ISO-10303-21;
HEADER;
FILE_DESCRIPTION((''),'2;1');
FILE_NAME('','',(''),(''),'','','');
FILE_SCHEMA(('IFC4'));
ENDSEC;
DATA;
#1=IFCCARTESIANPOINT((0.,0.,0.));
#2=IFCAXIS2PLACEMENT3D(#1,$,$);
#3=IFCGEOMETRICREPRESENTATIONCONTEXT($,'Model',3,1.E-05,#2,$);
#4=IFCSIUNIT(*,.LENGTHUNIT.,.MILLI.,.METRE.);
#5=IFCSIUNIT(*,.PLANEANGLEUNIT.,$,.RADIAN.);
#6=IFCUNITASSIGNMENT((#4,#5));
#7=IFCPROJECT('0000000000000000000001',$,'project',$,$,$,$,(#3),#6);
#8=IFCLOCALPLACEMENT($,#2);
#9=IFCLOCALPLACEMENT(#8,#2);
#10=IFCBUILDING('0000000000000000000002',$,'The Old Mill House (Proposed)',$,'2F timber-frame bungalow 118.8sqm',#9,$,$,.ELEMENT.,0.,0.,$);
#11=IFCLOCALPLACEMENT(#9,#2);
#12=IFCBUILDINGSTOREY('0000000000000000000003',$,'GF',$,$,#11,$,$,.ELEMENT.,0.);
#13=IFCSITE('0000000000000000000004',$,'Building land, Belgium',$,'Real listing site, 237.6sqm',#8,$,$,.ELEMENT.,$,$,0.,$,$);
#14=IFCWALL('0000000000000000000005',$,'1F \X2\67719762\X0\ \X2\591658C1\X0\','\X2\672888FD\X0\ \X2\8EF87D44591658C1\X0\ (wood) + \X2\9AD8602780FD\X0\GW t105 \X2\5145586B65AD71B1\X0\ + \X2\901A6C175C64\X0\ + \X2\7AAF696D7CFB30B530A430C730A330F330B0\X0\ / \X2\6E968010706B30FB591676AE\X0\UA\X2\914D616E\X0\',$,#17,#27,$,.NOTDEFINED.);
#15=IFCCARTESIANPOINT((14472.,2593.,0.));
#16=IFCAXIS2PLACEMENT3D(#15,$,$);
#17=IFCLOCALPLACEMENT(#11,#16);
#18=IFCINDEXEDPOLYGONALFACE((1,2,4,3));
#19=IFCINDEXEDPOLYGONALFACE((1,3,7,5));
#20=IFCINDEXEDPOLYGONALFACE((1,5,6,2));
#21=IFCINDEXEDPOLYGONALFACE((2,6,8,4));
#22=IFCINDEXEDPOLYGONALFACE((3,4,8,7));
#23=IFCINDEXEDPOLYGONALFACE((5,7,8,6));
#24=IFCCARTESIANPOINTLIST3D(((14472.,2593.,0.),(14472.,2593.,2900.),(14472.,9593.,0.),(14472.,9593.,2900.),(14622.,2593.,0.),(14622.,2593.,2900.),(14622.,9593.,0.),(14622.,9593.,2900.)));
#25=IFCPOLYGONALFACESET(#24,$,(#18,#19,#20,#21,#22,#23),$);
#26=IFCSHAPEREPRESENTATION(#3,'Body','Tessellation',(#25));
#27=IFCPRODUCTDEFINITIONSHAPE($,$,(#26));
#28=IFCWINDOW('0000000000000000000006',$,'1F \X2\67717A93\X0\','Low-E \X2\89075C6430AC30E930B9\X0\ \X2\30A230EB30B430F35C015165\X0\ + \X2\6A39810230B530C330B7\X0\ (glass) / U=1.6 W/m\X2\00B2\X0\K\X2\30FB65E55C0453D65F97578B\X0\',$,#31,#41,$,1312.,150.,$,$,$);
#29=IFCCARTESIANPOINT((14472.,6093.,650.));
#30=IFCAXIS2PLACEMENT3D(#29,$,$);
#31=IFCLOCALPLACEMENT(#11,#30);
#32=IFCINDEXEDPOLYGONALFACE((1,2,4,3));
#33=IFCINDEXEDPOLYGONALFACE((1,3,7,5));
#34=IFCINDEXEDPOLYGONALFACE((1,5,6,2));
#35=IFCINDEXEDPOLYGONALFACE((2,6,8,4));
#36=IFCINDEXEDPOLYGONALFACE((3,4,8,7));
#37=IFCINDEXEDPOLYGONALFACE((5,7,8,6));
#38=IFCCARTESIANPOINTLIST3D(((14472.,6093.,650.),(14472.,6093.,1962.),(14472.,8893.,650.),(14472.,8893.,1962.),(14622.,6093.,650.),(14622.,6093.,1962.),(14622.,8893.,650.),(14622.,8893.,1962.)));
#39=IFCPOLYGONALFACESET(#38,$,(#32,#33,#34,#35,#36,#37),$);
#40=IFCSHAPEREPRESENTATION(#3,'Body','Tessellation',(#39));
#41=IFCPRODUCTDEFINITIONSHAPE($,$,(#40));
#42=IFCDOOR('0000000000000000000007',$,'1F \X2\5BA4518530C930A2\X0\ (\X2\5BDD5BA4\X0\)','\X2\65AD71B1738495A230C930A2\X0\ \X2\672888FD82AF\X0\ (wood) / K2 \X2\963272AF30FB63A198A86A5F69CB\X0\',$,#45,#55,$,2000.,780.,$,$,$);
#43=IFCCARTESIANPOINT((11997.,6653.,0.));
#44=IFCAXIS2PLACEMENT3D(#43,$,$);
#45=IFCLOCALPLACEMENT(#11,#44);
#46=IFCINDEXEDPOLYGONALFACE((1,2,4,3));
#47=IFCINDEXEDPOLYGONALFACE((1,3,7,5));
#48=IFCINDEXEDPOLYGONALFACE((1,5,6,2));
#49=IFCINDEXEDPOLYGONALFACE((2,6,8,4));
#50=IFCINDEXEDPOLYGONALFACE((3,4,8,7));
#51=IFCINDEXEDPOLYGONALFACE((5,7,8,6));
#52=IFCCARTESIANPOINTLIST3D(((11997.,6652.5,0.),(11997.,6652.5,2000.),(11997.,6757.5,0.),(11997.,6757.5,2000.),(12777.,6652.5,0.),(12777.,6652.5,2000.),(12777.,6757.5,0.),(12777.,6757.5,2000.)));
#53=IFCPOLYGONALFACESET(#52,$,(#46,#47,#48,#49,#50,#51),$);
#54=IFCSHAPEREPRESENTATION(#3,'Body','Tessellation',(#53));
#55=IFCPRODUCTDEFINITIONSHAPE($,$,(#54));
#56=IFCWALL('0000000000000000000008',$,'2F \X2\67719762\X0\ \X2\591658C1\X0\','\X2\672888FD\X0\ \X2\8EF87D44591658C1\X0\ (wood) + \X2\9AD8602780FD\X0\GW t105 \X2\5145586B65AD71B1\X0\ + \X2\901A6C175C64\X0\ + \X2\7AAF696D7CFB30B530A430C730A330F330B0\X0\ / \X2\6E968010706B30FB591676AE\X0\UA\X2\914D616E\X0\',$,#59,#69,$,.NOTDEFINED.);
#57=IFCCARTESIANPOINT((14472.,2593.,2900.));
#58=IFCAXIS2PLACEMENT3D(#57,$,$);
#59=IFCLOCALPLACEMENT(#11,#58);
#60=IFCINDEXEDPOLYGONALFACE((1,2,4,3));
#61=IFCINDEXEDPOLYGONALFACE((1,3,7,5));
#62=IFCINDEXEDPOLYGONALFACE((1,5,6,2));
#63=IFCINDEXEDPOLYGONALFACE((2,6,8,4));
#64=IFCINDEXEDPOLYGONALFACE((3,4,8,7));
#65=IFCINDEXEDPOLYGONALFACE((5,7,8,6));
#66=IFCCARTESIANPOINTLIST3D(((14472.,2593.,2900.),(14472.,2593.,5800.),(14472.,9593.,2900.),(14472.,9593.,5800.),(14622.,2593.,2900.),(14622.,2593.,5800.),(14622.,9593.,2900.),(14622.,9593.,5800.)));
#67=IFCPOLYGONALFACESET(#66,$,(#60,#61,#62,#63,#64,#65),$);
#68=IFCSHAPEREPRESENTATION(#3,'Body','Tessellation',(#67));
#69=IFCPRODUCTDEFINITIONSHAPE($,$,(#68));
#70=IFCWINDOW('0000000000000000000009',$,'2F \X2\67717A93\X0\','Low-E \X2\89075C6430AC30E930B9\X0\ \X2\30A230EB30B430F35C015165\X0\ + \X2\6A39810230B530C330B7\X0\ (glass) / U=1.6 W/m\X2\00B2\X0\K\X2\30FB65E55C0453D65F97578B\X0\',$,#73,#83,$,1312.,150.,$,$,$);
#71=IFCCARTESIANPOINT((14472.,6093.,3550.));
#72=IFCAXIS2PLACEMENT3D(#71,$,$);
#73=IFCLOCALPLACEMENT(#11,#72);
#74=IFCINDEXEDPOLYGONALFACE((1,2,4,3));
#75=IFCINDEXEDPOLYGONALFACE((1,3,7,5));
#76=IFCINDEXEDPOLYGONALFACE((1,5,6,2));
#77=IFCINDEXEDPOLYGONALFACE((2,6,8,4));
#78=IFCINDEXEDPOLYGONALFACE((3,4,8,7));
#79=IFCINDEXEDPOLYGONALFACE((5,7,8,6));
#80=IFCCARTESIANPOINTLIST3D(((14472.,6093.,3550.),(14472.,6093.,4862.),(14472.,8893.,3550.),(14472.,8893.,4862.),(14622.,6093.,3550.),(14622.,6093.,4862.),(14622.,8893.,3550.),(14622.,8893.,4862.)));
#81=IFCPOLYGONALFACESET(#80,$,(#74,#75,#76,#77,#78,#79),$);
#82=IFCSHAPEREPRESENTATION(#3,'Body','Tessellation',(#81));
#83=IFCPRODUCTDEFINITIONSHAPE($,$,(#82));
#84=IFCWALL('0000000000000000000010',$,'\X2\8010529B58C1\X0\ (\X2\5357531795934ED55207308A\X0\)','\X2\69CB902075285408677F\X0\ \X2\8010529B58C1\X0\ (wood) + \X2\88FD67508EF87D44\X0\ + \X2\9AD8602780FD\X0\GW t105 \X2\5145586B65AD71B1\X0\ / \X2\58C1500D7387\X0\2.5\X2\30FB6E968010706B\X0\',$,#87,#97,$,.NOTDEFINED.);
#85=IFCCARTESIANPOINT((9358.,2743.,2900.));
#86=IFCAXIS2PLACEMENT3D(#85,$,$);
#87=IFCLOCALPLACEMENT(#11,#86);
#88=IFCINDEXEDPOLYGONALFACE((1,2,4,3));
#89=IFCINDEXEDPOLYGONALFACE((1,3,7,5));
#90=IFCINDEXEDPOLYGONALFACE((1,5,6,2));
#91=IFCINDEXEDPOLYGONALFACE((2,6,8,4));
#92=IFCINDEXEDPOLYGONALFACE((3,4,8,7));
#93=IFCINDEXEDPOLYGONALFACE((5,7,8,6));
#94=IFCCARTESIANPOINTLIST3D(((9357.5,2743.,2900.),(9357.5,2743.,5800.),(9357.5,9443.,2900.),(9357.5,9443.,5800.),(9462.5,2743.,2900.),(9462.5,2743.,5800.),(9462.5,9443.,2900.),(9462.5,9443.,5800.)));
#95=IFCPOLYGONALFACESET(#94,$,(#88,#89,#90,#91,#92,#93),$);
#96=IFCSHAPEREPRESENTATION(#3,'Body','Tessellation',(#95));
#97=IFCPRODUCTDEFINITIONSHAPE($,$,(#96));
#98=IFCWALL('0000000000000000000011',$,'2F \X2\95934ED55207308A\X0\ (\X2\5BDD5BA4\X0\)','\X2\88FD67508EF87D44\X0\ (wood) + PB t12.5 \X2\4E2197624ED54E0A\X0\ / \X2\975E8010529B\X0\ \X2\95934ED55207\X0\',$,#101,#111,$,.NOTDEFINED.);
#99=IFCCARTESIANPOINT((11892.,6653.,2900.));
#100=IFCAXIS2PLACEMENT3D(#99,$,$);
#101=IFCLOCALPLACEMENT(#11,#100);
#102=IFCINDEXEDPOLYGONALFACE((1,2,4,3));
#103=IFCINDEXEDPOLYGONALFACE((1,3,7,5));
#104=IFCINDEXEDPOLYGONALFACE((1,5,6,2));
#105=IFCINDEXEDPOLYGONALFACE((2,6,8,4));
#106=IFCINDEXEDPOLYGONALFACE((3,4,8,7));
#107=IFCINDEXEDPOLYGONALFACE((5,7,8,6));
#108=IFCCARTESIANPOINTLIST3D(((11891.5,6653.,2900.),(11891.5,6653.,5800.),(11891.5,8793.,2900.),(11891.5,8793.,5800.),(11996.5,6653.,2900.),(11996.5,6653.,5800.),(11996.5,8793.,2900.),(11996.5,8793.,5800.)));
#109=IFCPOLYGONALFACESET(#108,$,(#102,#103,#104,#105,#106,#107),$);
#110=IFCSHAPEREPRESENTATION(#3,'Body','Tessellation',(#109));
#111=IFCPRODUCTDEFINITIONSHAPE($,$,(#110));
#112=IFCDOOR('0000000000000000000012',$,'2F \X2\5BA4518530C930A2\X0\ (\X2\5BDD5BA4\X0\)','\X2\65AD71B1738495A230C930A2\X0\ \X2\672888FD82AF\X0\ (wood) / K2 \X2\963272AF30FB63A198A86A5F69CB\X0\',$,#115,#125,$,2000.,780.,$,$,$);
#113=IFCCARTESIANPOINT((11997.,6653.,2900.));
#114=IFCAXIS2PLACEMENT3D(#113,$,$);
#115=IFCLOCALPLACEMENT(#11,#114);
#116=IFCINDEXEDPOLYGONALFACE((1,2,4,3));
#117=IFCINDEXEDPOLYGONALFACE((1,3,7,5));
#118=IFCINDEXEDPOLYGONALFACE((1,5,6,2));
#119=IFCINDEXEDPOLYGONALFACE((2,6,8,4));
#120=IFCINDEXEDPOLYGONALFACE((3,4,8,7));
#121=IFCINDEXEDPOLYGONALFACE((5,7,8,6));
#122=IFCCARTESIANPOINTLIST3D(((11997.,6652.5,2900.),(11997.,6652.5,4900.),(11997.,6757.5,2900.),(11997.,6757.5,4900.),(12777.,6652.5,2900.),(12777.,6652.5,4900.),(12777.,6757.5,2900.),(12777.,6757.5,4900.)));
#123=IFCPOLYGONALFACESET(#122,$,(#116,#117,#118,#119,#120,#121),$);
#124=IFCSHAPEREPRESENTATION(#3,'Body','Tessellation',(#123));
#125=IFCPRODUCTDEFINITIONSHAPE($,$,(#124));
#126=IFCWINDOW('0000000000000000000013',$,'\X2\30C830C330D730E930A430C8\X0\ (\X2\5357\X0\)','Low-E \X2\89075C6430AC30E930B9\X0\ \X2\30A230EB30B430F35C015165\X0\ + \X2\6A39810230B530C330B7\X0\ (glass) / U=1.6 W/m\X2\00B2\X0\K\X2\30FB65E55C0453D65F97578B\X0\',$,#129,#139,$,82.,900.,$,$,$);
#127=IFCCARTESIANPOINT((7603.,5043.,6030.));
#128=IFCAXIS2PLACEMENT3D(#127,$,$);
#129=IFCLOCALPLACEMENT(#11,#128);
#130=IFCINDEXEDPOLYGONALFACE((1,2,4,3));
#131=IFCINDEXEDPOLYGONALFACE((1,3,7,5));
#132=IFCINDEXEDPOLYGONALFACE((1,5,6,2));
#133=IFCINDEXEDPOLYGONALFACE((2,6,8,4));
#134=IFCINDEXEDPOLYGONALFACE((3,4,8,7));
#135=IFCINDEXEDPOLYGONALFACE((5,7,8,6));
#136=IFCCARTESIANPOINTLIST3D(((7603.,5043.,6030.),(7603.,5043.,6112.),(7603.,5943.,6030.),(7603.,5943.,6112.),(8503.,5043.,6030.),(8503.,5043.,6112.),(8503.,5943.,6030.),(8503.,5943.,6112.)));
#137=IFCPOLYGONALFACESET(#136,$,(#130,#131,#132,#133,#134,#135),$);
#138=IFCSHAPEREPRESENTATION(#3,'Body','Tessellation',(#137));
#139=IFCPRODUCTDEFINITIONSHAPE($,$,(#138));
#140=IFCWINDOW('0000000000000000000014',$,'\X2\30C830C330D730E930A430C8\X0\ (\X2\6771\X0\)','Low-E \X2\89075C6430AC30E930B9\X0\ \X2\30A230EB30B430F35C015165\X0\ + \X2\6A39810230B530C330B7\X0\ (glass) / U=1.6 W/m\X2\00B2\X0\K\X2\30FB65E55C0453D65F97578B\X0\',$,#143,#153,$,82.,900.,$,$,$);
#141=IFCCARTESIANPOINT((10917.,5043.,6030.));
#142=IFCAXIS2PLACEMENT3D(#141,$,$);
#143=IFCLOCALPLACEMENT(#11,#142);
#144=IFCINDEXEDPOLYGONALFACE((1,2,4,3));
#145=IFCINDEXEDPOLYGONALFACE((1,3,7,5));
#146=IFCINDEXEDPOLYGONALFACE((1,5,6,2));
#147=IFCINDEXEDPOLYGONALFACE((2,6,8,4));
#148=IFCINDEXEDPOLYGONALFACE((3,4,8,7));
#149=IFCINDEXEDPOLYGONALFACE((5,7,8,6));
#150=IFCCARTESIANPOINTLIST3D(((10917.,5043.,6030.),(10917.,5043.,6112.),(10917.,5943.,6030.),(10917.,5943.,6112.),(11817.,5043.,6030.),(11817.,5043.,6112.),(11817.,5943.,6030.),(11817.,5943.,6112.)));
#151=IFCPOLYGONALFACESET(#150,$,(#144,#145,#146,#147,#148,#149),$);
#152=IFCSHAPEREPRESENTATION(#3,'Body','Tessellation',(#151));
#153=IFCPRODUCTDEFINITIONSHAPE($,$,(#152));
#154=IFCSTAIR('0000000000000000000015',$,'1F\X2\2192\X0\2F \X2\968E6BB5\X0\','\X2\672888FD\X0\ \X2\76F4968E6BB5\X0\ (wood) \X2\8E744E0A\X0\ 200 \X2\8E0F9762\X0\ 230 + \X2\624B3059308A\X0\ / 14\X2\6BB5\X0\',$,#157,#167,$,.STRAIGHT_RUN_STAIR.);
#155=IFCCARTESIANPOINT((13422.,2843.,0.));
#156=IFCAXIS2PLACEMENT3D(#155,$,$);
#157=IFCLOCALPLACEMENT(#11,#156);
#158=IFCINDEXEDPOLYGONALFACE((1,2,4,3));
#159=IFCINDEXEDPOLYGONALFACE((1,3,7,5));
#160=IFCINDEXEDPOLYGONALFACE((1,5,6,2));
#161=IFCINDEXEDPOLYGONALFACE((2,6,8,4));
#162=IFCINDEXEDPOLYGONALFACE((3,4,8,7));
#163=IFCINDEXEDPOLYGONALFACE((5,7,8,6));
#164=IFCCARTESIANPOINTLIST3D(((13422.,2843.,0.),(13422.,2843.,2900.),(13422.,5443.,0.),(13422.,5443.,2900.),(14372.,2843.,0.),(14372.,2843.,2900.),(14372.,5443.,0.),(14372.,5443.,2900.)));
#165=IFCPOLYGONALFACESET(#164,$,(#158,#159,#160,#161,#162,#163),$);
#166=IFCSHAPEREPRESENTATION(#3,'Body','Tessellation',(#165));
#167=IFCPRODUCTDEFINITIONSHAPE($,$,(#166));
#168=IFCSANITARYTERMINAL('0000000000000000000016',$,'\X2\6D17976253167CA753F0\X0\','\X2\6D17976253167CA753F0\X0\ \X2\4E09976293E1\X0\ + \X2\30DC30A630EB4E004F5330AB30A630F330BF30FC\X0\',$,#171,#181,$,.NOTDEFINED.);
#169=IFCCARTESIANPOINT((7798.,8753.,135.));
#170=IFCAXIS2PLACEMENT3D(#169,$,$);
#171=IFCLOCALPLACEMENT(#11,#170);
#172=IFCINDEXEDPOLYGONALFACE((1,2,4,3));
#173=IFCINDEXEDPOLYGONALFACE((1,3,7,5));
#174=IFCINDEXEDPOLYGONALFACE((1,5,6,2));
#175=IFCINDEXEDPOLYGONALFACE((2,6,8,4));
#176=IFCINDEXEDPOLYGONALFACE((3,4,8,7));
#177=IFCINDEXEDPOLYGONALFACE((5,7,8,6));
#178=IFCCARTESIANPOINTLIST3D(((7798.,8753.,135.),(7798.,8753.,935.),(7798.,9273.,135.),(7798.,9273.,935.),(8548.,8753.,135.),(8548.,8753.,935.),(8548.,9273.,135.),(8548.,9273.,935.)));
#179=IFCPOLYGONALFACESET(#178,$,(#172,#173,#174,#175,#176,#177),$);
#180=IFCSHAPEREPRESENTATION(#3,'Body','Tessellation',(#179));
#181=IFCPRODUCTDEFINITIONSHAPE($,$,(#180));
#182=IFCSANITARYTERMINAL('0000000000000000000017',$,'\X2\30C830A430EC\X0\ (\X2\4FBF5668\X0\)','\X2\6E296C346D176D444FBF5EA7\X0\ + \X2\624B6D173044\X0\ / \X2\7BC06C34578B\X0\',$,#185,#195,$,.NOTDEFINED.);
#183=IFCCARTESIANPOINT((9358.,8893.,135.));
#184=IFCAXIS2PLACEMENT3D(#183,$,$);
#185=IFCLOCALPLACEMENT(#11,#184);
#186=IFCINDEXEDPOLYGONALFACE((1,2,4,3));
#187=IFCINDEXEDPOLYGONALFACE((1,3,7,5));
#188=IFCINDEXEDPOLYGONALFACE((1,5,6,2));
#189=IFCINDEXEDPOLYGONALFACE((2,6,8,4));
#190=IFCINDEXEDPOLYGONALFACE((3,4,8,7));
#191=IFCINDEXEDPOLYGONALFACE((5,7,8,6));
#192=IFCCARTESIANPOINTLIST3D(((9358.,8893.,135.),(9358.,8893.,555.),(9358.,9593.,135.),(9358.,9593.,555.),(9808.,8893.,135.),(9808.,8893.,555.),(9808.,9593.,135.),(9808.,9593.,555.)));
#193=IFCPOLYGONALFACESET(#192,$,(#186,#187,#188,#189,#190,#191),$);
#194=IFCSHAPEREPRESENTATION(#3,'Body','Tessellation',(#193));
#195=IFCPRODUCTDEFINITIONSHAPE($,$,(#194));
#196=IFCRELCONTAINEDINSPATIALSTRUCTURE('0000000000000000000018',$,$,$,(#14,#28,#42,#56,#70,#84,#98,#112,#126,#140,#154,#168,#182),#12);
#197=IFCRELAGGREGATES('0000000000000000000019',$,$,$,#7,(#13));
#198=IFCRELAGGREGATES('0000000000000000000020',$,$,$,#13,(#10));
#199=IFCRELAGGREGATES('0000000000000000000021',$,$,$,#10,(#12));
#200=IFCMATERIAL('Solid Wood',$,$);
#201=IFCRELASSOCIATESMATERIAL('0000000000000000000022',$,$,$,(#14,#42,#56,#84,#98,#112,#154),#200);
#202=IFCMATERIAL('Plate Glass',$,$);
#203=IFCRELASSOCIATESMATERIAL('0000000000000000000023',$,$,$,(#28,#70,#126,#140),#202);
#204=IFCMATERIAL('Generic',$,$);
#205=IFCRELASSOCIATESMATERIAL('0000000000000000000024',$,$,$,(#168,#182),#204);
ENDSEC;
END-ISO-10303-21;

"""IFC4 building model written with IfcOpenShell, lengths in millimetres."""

from ifc_helpers import new_model, si_unit, frame, frame_2d, origin, place, context, project, spatial, rectangle, extrude, material, element, fill, save


model = new_model("IFC4")

# Units and contexts
model_context = context("Model", 3, precision=1e-05, world=origin())
ifc_project = project(units=[si_unit("LENGTHUNIT", "METRE", prefix="MILLI"), si_unit("PLANEANGLEUNIT", "RADIAN")], contexts=[model_context])

# Site, building, storey
site_placement = place(None, origin())
site = spatial("IfcSite", under=ifc_project, at=site_placement, Name="Building land, Belgium", ObjectType="Real listing site, 237.6sqm", CompositionType="ELEMENT", RefElevation=0.0)
building_placement = place(site_placement, origin())
building = spatial("IfcBuilding", under=site, at=building_placement, Name="The Old Mill House (Proposed)", ObjectType="2F timber-frame bungalow 118.8sqm", CompositionType="ELEMENT", ElevationOfRefHeight=0.0, ElevationOfTerrain=0.0)
storey_placement = place(building_placement, origin())
storey = spatial("IfcBuildingStorey", under=building, at=storey_placement, Name="GF", CompositionType="ELEMENT", Elevation=0.0)

# Wall, opening, window
ifc_material_1 = material(Name="Solid Wood")
wall_1_placement = place(storey_placement, frame((14472.0, 2593.0, 0.0)))
wall_1 = element("IfcWall", 1, at=wall_1_placement, inside=storey, material=ifc_material_1, Name="1F 東面 外壁", Description="木製 軸組外壁 (wood) + 高性能GW t105 充填断熱 + 通気層 + 窯業系サイディング / 準耐火・外皮UA配慮", PredefinedType="NOTDEFINED", context=model_context, shape_type="SweptSolid", body=[
    extrude(rectangle(XDim=150.0, YDim=7000.0, at=frame_2d((75.0, 3500.0))), frame((14472.0, 2593.0, 0.0)), (0.0, 0.0, 1.0), 2900.0),
])
opening_1_placement = place(storey_placement, frame((14472.0, 6093.0, 650.0)))
opening_1 = element("IfcOpeningElement", 2, at=opening_1_placement, cuts=wall_1, PredefinedType="NOTDEFINED", context=model_context, shape_type="SweptSolid", body=[
    extrude(rectangle(XDim=150.0, YDim=2800.0, at=frame_2d((75.0, 1400.0))), frame((14472.0, 6093.0, 650.0)), (0.0, 0.0, 1.0), 1312.0),
])
ifc_material_2 = material(Name="Plate Glass")
window_1_placement = place(storey_placement, frame((14472.0, 6093.0, 650.0)))
window_1 = element("IfcWindow", 3, at=window_1_placement, inside=storey, material=ifc_material_2, Name="1F 東窓", Description="Low-E 複層ガラス アルゴン封入 + 樹脂サッシ (glass) / U=1.6 W/m²K・日射取得型", OverallHeight=1312.0, OverallWidth=150.0, context=model_context, shape_type="SweptSolid", body=[
    extrude(rectangle(XDim=150.0, YDim=2800.0, at=frame_2d((75.0, 1400.0))), frame((14472.0, 6093.0, 650.0)), (0.0, 0.0, 1.0), 1312.0),
])
fill(opening_1, window_1)

# Door
door_1_placement = place(storey_placement, frame((11997.0, 6653.0, 0.0)))
element("IfcDoor", 4, at=door_1_placement, inside=storey, material=ifc_material_1, Name="1F 室内ドア (寝室)", Description="断熱玄関ドア 木製芯 (wood) / K2 防犯・採風機構", OverallHeight=2000.0, OverallWidth=780.0, context=model_context, shape_type="SweptSolid", body=[
    extrude(rectangle(XDim=780.0, YDim=105.0, at=frame_2d((390.0, 52.0))), frame((11997.0, 6653.0, 0.0)), (0.0, 0.0, 1.0), 2000.0),
])

# Wall, opening, window
wall_2_placement = place(storey_placement, frame((14472.0, 2593.0, 2900.0)))
wall_2 = element("IfcWall", 5, at=wall_2_placement, inside=storey, material=ifc_material_1, Name="2F 東面 外壁", Description="木製 軸組外壁 (wood) + 高性能GW t105 充填断熱 + 通気層 + 窯業系サイディング / 準耐火・外皮UA配慮", PredefinedType="NOTDEFINED", context=model_context, shape_type="SweptSolid", body=[
    extrude(rectangle(XDim=150.0, YDim=7000.0, at=frame_2d((75.0, 3500.0))), frame((14472.0, 2593.0, 2900.0)), (0.0, 0.0, 1.0), 2900.0),
])
opening_2_placement = place(storey_placement, frame((14472.0, 6093.0, 3550.0)))
opening_2 = element("IfcOpeningElement", 6, at=opening_2_placement, cuts=wall_2, PredefinedType="NOTDEFINED", context=model_context, shape_type="SweptSolid", body=[
    extrude(rectangle(XDim=150.0, YDim=2800.0, at=frame_2d((75.0, 1400.0))), frame((14472.0, 6093.0, 3550.0)), (0.0, 0.0, 1.0), 1312.0),
])
window_2_placement = place(storey_placement, frame((14472.0, 6093.0, 3550.0)))
window_2 = element("IfcWindow", 7, at=window_2_placement, inside=storey, material=ifc_material_2, Name="2F 東窓", Description="Low-E 複層ガラス アルゴン封入 + 樹脂サッシ (glass) / U=1.6 W/m²K・日射取得型", OverallHeight=1312.0, OverallWidth=150.0, context=model_context, shape_type="SweptSolid", body=[
    extrude(rectangle(XDim=150.0, YDim=2800.0, at=frame_2d((75.0, 1400.0))), frame((14472.0, 6093.0, 3550.0)), (0.0, 0.0, 1.0), 1312.0),
])
fill(opening_2, window_2)

# Walls
wall_3_placement = place(storey_placement, frame((9358.0, 2743.0, 2900.0)))
element("IfcWall", 8, at=wall_3_placement, inside=storey, material=ifc_material_1, Name="耐力壁 (南北間仕切り)", Description="構造用合板 耐力壁 (wood) + 製材軸組 + 高性能GW t105 充填断熱 / 壁倍率2.5・準耐火", PredefinedType="NOTDEFINED", context=model_context, shape_type="SweptSolid", body=[
    extrude(rectangle(XDim=105.0, YDim=6700.0, at=frame_2d((52.0, 3350.0))), frame((9358.0, 2743.0, 2900.0)), (0.0, 0.0, 1.0), 2900.0),
])
wall_4_placement = place(storey_placement, frame((11892.0, 6653.0, 2900.0)))
element("IfcWall", 9, at=wall_4_placement, inside=storey, material=ifc_material_1, Name="2F 間仕切り (寝室)", Description="製材軸組 (wood) + PB t12.5 両面仕上 / 非耐力 間仕切", PredefinedType="NOTDEFINED", context=model_context, shape_type="SweptSolid", body=[
    extrude(rectangle(XDim=105.0, YDim=2140.0, at=frame_2d((52.0, 1070.0))), frame((11892.0, 6653.0, 2900.0)), (0.0, 0.0, 1.0), 2900.0),
])

# Door
door_2_placement = place(storey_placement, frame((11997.0, 6653.0, 2900.0)))
element("IfcDoor", 10, at=door_2_placement, inside=storey, material=ifc_material_1, Name="2F 室内ドア (寝室)", Description="断熱玄関ドア 木製芯 (wood) / K2 防犯・採風機構", OverallHeight=2000.0, OverallWidth=780.0, context=model_context, shape_type="SweptSolid", body=[
    extrude(rectangle(XDim=780.0, YDim=105.0, at=frame_2d((390.0, 52.0))), frame((11997.0, 6653.0, 2900.0)), (0.0, 0.0, 1.0), 2000.0),
])

# Windows
window_3_placement = place(storey_placement, frame((7603.0, 5043.0, 6030.0)))
element("IfcWindow", 11, at=window_3_placement, inside=storey, material=ifc_material_2, Name="トップライト (南)", Description="Low-E 複層ガラス アルゴン封入 + 樹脂サッシ (glass) / U=1.6 W/m²K・日射取得型", OverallHeight=82.0, OverallWidth=900.0, context=model_context, shape_type="SweptSolid", body=[
    extrude(rectangle(XDim=900.0, YDim=900.0, at=frame_2d((450.0, 450.0))), frame((7603.0, 5043.0, 6030.0)), (0.0, 0.0, 1.0), 82.0),
])
window_4_placement = place(storey_placement, frame((10917.0, 5043.0, 6030.0)))
element("IfcWindow", 12, at=window_4_placement, inside=storey, material=ifc_material_2, Name="トップライト (東)", Description="Low-E 複層ガラス アルゴン封入 + 樹脂サッシ (glass) / U=1.6 W/m²K・日射取得型", OverallHeight=82.0, OverallWidth=900.0, context=model_context, shape_type="SweptSolid", body=[
    extrude(rectangle(XDim=900.0, YDim=900.0, at=frame_2d((450.0, 450.0))), frame((10917.0, 5043.0, 6030.0)), (0.0, 0.0, 1.0), 82.0),
])

# Stair
stair_placement = place(storey_placement, frame((13422.0, 2843.0, 0.0)))
element("IfcStair", 13, at=stair_placement, inside=storey, material=ifc_material_1, Name="1F→2F 階段", Description="木製 直階段 (wood) 蹴上 200 踏面 230 + 手すり / 14段", PredefinedType="STRAIGHT_RUN_STAIR", context=model_context, shape_type="SweptSolid", body=[
    extrude(rectangle(XDim=950.0, YDim=2600.0, at=frame_2d((475.0, 1300.0))), frame((13422.0, 2843.0, 0.0)), (0.0, 0.0, 1.0), 2900.0),
])

# Sanitary terminals
ifc_material_3 = material(Name="Generic")
sanitary_terminal_1_placement = place(storey_placement, frame((7798.0, 8753.0, 135.0)))
element("IfcSanitaryTerminal", 14, at=sanitary_terminal_1_placement, inside=storey, material=ifc_material_3, Name="洗面化粧台", Description="洗面化粧台 三面鏡 + ボウル一体カウンター", PredefinedType="NOTDEFINED", context=model_context, shape_type="SweptSolid", body=[
    extrude(rectangle(XDim=750.0, YDim=520.0, at=frame_2d((375.0, 260.0))), frame((7798.0, 8753.0, 135.0)), (0.0, 0.0, 1.0), 800.0),
])
sanitary_terminal_2_placement = place(storey_placement, frame((9358.0, 8893.0, 135.0)))
element("IfcSanitaryTerminal", 15, at=sanitary_terminal_2_placement, inside=storey, material=ifc_material_3, Name="トイレ (便器)", Description="温水洗浄便座 + 手洗い / 節水型", PredefinedType="NOTDEFINED", context=model_context, shape_type="SweptSolid", body=[
    extrude(rectangle(XDim=450.0, YDim=700.0, at=frame_2d((225.0, 350.0))), frame((9358.0, 8893.0, 135.0)), (0.0, 0.0, 1.0), 420.0),
])

save(model, "model.ifc")
